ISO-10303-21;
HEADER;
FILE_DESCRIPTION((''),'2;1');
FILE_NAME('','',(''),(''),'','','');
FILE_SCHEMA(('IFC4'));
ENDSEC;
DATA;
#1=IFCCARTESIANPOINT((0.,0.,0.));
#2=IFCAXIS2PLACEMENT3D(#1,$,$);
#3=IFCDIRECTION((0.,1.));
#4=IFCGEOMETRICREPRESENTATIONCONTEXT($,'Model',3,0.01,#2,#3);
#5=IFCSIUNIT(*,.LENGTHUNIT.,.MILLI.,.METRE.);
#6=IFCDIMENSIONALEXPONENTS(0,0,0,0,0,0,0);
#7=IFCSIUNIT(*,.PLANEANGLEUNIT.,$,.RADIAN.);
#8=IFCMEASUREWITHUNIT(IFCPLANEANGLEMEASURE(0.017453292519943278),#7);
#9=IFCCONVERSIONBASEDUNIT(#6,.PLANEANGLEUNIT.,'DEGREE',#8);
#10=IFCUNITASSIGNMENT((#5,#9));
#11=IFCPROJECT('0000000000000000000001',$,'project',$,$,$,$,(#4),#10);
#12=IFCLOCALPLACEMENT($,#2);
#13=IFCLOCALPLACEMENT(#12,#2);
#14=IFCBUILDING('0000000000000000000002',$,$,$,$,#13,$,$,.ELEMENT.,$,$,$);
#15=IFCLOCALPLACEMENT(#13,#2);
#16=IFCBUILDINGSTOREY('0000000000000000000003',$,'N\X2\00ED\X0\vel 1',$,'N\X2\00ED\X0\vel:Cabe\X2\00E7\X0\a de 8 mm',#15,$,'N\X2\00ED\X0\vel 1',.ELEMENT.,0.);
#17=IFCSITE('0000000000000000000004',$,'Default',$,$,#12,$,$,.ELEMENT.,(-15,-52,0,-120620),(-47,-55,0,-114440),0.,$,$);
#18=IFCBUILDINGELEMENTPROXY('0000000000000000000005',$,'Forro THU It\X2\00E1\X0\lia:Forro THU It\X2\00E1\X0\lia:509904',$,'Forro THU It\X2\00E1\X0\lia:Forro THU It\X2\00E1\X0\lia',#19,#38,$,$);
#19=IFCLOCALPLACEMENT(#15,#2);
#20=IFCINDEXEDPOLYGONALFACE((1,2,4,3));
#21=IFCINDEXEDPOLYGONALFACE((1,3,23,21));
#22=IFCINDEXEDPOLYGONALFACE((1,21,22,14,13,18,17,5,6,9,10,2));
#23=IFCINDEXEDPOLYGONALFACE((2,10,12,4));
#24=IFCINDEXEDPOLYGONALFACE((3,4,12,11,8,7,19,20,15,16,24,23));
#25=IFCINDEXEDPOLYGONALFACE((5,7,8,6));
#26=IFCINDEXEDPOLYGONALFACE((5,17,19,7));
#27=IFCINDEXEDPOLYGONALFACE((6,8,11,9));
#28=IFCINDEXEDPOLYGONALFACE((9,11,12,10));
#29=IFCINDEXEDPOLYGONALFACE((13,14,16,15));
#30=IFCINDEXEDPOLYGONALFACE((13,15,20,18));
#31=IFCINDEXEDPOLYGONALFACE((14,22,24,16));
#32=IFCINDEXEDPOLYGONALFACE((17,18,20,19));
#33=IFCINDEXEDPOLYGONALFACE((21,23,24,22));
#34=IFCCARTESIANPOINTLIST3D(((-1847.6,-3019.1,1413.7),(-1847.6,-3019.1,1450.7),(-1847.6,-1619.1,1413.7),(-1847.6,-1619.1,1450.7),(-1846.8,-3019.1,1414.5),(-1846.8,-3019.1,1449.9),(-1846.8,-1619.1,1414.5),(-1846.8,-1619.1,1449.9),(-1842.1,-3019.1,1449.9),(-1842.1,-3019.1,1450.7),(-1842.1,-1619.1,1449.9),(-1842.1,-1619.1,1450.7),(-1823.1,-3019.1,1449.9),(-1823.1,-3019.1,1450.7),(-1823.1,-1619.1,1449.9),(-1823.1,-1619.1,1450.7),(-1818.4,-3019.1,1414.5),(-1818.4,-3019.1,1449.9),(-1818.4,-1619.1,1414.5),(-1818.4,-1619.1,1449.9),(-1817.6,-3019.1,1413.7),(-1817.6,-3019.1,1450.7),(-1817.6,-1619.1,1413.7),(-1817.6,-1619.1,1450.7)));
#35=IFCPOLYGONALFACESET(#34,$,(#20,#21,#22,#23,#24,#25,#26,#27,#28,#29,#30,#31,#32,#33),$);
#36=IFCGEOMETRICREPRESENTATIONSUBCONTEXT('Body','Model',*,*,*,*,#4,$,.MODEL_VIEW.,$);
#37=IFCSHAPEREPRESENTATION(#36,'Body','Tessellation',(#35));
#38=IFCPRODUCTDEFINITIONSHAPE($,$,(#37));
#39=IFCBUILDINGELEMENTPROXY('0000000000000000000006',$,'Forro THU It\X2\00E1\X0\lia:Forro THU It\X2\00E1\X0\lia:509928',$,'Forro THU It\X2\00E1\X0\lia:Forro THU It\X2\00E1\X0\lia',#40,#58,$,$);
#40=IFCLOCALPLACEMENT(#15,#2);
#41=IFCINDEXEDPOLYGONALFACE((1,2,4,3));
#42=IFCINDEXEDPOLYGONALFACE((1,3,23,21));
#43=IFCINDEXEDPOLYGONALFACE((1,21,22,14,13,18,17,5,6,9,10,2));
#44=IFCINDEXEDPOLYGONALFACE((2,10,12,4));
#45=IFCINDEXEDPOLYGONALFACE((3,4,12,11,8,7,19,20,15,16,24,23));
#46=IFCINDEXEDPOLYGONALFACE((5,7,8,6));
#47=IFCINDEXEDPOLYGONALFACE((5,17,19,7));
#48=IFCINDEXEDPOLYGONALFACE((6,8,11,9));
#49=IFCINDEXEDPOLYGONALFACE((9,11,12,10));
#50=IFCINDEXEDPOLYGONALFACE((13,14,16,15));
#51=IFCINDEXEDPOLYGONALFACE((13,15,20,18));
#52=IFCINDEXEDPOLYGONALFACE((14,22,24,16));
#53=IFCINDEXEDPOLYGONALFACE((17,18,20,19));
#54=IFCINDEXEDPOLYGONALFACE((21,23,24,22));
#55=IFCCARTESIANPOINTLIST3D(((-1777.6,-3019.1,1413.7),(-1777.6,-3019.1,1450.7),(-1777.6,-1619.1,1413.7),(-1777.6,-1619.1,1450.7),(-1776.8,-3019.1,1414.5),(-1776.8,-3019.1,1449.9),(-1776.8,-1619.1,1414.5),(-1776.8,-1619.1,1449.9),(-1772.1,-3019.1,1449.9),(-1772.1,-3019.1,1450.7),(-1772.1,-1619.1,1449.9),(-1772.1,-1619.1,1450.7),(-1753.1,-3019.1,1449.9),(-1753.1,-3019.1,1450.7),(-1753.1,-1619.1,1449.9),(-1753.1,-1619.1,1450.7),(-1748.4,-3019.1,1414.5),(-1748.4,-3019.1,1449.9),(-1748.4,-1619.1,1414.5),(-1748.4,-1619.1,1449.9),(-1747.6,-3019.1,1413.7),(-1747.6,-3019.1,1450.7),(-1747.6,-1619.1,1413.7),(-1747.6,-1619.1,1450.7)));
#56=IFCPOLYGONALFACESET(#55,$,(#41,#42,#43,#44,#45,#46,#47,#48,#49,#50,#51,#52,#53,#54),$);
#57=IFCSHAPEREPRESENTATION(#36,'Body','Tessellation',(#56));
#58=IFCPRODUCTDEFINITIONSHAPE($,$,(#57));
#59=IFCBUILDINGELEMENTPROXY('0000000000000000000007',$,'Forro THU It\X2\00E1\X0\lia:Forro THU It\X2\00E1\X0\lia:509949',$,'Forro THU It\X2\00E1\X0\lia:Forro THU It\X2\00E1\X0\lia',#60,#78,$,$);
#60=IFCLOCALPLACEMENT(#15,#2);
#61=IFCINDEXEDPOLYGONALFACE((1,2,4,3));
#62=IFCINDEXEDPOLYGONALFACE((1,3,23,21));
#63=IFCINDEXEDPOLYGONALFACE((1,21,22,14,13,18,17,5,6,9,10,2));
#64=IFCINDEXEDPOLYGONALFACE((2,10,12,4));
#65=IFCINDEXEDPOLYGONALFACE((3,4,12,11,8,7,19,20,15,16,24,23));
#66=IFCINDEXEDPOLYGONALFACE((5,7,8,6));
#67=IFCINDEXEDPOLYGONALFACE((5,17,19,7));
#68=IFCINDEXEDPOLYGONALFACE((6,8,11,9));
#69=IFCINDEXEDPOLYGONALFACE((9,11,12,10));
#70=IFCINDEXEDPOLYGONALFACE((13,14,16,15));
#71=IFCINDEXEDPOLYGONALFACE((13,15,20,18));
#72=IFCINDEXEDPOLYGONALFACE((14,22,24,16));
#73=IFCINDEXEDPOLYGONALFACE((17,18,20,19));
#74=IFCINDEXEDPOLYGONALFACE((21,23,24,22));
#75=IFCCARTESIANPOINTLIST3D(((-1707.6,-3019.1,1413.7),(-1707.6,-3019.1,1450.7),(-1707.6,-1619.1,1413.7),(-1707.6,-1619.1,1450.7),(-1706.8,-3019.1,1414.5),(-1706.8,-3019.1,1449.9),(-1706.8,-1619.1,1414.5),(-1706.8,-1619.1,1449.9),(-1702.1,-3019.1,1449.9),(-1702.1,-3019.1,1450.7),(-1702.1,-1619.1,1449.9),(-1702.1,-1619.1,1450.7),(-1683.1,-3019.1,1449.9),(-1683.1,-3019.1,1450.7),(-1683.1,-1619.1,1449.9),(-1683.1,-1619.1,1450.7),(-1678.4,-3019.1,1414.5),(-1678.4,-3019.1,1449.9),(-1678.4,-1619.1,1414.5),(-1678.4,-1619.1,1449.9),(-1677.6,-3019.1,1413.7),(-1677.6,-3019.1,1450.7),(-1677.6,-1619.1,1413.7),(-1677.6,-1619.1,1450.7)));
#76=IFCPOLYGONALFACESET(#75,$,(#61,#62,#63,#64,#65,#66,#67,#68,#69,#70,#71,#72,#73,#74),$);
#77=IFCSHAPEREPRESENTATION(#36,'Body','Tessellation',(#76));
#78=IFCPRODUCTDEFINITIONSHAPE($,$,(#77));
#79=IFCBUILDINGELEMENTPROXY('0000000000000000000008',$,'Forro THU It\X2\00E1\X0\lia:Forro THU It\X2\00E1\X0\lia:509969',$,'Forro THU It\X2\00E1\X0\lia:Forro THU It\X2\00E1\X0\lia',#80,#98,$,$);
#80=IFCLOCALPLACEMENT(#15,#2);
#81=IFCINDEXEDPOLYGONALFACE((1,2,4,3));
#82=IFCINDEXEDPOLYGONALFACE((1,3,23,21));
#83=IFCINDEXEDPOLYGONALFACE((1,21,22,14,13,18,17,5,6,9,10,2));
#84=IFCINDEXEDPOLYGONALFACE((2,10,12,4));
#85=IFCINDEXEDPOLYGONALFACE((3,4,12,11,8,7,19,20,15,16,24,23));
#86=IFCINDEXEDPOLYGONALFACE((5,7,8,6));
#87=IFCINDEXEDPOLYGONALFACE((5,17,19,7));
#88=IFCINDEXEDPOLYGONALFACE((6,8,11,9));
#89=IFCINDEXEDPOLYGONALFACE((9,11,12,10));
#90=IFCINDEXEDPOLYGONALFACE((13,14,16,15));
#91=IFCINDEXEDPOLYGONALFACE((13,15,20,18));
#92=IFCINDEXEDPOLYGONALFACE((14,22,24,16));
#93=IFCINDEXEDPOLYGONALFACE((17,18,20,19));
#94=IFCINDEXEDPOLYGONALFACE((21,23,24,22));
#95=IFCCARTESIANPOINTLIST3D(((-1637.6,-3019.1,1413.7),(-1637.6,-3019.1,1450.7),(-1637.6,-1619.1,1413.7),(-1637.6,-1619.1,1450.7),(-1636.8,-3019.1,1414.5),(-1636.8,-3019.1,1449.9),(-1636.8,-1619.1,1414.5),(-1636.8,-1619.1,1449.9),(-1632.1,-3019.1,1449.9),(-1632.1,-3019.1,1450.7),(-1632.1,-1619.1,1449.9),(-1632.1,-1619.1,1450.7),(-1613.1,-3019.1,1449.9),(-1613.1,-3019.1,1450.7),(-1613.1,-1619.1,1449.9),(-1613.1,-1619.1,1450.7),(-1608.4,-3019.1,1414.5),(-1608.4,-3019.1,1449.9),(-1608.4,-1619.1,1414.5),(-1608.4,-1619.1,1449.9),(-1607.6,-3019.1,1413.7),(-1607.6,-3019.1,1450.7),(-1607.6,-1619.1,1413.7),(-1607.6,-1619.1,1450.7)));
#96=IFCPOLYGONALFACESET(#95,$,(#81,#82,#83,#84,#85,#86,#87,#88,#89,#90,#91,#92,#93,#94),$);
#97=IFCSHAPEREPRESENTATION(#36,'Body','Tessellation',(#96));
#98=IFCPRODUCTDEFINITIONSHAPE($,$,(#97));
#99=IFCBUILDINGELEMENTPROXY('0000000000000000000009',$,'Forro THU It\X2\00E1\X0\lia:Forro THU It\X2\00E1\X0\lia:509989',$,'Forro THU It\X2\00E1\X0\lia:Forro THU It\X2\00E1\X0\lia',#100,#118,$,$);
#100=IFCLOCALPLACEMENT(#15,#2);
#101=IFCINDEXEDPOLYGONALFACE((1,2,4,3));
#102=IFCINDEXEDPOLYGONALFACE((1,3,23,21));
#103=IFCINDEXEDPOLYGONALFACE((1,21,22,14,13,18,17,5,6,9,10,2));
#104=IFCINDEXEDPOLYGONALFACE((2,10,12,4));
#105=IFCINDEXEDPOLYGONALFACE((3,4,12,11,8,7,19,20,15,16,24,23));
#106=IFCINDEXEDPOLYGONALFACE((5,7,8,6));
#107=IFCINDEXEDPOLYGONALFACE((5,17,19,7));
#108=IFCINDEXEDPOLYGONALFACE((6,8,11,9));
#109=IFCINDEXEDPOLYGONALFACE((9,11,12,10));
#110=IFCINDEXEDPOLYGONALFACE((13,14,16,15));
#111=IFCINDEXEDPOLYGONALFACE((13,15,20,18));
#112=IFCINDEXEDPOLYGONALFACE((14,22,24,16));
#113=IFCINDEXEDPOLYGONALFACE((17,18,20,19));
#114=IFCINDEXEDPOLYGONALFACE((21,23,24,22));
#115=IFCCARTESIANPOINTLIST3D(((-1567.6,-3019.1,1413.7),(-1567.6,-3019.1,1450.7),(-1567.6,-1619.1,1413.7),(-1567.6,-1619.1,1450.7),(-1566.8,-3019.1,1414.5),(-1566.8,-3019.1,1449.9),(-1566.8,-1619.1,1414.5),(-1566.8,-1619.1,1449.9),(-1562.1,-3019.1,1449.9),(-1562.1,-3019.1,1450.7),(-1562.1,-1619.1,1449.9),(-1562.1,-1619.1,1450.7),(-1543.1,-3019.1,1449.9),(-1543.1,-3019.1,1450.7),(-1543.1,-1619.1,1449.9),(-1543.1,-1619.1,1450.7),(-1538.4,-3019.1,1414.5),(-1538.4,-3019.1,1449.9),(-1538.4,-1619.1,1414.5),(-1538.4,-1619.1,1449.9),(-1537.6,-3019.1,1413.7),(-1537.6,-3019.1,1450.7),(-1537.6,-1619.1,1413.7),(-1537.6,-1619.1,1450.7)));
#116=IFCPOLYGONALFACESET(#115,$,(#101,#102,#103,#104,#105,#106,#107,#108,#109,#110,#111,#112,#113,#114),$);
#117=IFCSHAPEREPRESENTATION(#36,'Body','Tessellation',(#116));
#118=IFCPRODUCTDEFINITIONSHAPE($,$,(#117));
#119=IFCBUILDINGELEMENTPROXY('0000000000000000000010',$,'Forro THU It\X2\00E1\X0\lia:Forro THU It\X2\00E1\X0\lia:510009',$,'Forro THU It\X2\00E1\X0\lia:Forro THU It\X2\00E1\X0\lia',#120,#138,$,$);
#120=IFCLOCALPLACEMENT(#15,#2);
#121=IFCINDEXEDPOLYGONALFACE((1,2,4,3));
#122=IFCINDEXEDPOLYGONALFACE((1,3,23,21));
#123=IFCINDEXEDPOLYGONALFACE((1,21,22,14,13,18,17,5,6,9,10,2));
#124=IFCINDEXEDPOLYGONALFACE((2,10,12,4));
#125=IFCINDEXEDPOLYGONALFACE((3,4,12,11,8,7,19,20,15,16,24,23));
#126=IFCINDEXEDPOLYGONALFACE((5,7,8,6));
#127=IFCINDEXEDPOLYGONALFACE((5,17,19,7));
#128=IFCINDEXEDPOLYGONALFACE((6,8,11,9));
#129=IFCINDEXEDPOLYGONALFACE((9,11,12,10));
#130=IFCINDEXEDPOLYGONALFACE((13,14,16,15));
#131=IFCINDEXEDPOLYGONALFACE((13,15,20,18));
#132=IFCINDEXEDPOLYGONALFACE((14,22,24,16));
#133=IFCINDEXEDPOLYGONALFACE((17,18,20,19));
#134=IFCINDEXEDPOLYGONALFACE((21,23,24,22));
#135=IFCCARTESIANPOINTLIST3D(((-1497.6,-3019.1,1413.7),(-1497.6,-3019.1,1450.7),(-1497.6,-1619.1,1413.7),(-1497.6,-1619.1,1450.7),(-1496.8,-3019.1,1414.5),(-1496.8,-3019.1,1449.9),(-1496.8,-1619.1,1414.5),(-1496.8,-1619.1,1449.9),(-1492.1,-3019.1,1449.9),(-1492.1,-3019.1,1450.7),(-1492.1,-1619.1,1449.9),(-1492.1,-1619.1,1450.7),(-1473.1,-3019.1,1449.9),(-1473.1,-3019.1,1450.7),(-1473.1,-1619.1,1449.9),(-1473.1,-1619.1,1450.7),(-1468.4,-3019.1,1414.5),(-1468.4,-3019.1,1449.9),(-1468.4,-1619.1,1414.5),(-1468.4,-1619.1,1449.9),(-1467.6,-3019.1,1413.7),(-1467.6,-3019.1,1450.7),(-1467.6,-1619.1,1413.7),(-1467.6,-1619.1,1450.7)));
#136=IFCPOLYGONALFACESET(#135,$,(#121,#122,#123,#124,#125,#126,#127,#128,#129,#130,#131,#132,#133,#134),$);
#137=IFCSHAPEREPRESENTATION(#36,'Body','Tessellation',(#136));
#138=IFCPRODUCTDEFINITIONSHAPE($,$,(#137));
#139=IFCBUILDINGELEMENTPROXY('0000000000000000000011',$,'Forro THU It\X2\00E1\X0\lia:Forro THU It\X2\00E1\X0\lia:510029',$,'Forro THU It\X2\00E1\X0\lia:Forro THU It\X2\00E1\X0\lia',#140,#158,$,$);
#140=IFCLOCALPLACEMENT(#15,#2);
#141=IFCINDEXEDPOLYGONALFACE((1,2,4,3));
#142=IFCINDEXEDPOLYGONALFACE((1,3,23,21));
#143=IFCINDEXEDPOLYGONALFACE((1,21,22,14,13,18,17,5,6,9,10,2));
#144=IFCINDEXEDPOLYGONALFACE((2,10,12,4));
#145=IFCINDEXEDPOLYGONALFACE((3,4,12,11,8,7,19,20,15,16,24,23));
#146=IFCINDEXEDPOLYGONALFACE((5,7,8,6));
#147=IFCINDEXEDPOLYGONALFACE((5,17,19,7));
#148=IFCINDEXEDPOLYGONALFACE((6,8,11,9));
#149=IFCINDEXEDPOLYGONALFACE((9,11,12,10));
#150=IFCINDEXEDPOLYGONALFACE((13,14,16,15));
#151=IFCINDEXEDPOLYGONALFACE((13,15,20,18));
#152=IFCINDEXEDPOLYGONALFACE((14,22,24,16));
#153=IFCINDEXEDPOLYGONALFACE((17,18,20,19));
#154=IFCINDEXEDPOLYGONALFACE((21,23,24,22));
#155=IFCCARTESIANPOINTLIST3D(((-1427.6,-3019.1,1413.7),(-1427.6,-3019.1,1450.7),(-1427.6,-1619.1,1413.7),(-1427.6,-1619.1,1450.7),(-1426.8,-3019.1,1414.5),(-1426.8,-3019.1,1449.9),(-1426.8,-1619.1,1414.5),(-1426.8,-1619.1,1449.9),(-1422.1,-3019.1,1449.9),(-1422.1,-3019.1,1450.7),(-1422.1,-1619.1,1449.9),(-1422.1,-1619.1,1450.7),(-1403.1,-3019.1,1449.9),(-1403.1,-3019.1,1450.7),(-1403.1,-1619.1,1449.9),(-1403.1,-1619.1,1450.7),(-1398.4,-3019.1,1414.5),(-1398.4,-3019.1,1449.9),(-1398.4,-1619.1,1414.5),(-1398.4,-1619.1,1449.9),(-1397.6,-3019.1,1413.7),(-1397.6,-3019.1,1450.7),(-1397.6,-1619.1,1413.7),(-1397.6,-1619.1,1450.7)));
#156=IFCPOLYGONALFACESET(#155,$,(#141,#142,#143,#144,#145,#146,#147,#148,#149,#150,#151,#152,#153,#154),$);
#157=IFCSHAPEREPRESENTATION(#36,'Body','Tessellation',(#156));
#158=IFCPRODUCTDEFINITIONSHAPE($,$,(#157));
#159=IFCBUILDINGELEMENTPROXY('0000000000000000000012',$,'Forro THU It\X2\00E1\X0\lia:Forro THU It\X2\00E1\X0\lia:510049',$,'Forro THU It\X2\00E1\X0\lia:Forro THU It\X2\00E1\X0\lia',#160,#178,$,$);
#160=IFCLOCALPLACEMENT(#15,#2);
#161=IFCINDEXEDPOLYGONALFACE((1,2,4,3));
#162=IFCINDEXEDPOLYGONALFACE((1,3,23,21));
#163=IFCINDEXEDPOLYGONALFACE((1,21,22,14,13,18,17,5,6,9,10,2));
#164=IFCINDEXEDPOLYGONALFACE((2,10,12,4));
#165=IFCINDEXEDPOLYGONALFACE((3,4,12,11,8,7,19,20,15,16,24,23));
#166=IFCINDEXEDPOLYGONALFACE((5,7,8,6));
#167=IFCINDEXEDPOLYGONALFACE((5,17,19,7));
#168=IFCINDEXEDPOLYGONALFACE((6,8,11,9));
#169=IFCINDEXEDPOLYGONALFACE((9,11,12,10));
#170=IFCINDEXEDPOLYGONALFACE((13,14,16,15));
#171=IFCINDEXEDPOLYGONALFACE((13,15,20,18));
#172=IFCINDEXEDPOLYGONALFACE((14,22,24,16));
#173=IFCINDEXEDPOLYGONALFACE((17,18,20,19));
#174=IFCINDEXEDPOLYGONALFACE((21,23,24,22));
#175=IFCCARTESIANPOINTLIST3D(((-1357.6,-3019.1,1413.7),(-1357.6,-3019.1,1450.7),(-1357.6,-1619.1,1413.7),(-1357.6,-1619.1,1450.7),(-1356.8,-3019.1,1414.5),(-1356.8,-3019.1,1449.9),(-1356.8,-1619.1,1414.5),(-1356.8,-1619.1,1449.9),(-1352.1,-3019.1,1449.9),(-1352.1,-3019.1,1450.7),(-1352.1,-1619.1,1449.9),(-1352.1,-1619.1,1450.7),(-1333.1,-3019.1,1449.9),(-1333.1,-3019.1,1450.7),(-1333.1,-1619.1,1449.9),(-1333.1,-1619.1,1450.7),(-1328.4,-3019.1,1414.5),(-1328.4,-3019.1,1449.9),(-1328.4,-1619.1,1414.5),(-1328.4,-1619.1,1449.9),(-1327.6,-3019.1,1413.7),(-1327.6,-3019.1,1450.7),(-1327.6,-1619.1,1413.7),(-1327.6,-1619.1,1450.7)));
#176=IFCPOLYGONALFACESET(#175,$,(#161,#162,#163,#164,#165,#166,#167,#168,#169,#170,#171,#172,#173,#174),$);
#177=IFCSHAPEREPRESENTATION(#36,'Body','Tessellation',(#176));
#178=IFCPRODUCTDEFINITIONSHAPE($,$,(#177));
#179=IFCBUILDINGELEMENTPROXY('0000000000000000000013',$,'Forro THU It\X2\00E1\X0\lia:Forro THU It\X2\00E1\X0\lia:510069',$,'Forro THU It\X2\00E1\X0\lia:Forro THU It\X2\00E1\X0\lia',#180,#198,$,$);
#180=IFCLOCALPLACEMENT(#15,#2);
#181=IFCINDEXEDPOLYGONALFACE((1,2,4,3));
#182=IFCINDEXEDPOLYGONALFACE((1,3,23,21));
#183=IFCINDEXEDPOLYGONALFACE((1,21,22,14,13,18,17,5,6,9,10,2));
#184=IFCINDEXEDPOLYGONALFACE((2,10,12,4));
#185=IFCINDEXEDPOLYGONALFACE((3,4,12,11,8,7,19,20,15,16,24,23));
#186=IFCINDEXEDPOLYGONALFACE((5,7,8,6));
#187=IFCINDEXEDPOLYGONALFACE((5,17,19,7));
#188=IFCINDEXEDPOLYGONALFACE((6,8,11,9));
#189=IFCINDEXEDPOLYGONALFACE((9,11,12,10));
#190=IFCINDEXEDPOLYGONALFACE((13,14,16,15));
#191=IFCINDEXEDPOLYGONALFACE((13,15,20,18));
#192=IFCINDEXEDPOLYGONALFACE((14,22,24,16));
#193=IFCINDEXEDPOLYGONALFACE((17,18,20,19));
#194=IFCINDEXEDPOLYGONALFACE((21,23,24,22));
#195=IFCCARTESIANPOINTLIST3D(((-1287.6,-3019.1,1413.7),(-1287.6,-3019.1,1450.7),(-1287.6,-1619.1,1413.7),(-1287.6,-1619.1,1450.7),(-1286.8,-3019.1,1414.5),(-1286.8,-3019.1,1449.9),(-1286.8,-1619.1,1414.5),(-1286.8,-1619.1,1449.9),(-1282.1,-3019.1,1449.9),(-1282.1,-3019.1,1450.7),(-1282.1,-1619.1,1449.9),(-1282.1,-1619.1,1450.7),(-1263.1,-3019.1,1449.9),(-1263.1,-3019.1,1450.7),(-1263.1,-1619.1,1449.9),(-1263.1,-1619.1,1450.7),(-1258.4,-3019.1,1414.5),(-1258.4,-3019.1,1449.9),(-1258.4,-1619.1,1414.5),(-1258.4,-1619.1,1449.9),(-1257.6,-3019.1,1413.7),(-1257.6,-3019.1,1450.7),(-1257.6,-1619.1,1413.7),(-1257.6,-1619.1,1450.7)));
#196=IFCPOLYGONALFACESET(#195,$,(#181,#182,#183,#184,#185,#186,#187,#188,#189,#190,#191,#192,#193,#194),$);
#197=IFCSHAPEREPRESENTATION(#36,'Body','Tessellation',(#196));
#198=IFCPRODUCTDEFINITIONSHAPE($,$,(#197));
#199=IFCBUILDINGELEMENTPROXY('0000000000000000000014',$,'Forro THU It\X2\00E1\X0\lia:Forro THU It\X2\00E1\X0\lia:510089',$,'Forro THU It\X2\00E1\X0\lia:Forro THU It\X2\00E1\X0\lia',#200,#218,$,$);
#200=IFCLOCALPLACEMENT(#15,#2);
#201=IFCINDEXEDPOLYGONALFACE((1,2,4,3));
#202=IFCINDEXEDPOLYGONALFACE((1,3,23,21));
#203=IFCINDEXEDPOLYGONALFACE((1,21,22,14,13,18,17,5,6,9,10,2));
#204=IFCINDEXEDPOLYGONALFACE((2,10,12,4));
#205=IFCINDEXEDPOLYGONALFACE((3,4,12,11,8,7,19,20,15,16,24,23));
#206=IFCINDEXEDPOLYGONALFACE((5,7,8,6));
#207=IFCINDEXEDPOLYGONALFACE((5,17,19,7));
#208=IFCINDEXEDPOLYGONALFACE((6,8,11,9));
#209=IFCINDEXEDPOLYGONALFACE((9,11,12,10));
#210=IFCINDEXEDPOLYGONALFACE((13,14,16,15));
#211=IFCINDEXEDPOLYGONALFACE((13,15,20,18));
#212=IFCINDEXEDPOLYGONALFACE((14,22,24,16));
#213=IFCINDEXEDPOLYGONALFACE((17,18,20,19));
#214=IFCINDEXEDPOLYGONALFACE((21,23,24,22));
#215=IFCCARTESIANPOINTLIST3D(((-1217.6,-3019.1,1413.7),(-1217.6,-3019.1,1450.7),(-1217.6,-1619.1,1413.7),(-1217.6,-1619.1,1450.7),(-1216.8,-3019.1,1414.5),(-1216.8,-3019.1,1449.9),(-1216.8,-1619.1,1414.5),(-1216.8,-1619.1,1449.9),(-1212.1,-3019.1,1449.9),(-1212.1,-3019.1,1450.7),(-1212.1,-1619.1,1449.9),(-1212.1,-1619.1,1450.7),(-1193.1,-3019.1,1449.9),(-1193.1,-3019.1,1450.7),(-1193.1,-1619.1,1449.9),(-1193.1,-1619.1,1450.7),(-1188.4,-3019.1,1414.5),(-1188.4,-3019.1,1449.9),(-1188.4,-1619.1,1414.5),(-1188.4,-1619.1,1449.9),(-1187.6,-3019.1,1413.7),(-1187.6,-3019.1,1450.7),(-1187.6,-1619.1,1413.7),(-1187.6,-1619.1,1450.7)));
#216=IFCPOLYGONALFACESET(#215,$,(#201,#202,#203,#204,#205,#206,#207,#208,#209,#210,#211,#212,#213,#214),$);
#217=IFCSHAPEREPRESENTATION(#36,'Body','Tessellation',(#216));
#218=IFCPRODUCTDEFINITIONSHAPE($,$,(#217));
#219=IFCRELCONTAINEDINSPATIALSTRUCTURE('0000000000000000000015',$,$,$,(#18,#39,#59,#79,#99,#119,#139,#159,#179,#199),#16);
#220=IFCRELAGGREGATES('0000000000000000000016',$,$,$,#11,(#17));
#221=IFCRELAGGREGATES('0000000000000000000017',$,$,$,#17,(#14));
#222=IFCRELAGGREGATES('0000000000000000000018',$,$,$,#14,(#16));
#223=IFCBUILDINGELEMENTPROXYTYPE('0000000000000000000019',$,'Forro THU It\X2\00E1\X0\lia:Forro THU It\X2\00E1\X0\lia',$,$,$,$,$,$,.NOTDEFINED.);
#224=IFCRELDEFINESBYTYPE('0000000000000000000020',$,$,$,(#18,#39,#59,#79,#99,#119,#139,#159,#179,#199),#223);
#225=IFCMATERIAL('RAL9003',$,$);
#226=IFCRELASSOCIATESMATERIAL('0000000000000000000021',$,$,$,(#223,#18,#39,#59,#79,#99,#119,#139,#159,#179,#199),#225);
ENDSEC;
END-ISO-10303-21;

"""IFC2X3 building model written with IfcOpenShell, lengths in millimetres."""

from ifc_helpers import new_model, entity, si_unit, converted_unit, direction, frame, origin, place, context, subcontext, project, spatial, polyline, outline, extrude, source, transform, mapped, material, type_object, type_shapes, element, save


model = new_model("IFC2X3")

# Units and contexts
model_context = context("Model", 3, precision=0.01, world=origin(), true_north=direction((0.0, 1.0)))
body_context = subcontext(model_context, "Body", "Model", "MODEL_VIEW")
ifc_project = project(units=[si_unit("LENGTHUNIT", "METRE", prefix="MILLI"), converted_unit("PLANEANGLEUNIT", "DEGREE", entity("IfcPlaneAngleMeasure", 0.017453292519943278), si_unit("PLANEANGLEUNIT", "RADIAN"), dimensions=[0, 0, 0, 0, 0, 0, 0])], contexts=[model_context])

# Site, building, storey
site_placement = place(None, origin())
site = spatial("IfcSite", under=ifc_project, at=site_placement, Name="Default", CompositionType="ELEMENT", RefLatitude=(-15, -52, 0, -120620), RefLongitude=(-47, -55, 0, -114440), RefElevation=0.0)
building_placement = place(site_placement, origin())
building = spatial("IfcBuilding", under=site, at=building_placement, CompositionType="ELEMENT")
storey_placement = place(building_placement, origin())
storey = spatial("IfcBuildingStorey", under=building, at=storey_placement, Name="Nível 1", ObjectType="Nível:Cabeça de 8 mm", LongName="Nível 1", CompositionType="ELEMENT", Elevation=0.0)

# Building element proxies
ifc_material = material(Name="RAL9003")
building_element_proxy_type_1 = type_object("IfcBuildingElementProxyType", Name="Forro THU Itália:Forro THU Itália", PredefinedType="NOTDEFINED", material=ifc_material)
shared_shape_1 = source(origin(), body_context, "Body", "SweptSolid", [
    extrude(outline(polyline([(-15.0, -12.5), (-9.5, -12.5), (-9.5, -11.7), (-14.2, -11.7), (-14.2, 23.7), (14.2, 23.7), (14.2, -11.7), (9.5, -11.7), (9.5, -12.5), (15.0, -12.5), (15.0, 24.5), (-15.0, 24.5), (-15.0, -12.5)])), frame((0.0, -15.0, -12.5), z_axis=(1.0, 0.0, 0.0), x_axis=(0.0, -1.0, 0.0)), (0.0, 0.0, 1.0), 1400.0),
])
type_shapes(building_element_proxy_type_1, [shared_shape_1])
for number, where, z_axis, x_axis, name in (
    (1, (-1847.6, -3019.1, 1450.7), (0.0, 0.0, 1.0), (0.0, 1.0, 0.0), "Forro THU Itália:Forro THU Itália:509904"),
    (2, (-1777.6, -3019.1, 1450.7), (0.0, 0.0, 1.0), (0.0, 1.0, 0.0), "Forro THU Itália:Forro THU Itália:509928"),
    (3, (-1707.6, -3019.1, 1450.7), (0.0, 0.0, 1.0), (0.0, 1.0, 0.0), "Forro THU Itália:Forro THU Itália:509949"),
    (4, (-1637.6, -3019.1, 1450.7), (0.0, 0.0, 1.0), (0.0, 1.0, 0.0), "Forro THU Itália:Forro THU Itália:509969"),
    (5, (-1567.6, -3019.1, 1450.7), (0.0, 0.0, 1.0), (0.0, 1.0, 0.0), "Forro THU Itália:Forro THU Itália:509989"),
    (6, (-1497.6, -3019.1, 1450.7), (0.0, 0.0, 1.0), (0.0, 1.0, 0.0), "Forro THU Itália:Forro THU Itália:510009"),
    (7, (-1427.6, -3019.1, 1450.7), (0.0, 0.0, 1.0), (0.0, 1.0, 0.0), "Forro THU Itália:Forro THU Itália:510029"),
    (8, (-1357.6, -3019.1, 1450.7), (0.0, 0.0, 1.0), (0.0, 1.0, 0.0), "Forro THU Itália:Forro THU Itália:510049"),
    (9, (-1287.6, -3019.1, 1450.7), (0.0, 0.0, 1.0), (0.0, 1.0, 0.0), "Forro THU Itália:Forro THU Itália:510069"),
    (10, (-1217.6, -3019.1, 1450.7), (0.0, 0.0, 1.0), (0.0, 1.0, 0.0), "Forro THU Itália:Forro THU Itália:510089"),
):
    element("IfcBuildingElementProxy", number, at=place(storey_placement, frame(where, z_axis=z_axis, x_axis=x_axis)), inside=storey, type_object=building_element_proxy_type_1, material=ifc_material, Name=name, ObjectType="Forro THU Itália:Forro THU Itália", context=body_context, shape_type="MappedRepresentation", body=[
        mapped(shared_shape_1, transform((0.0, 0.0, 0.0), scale=1.0)),
    ])

save(model, "model.ifc")
